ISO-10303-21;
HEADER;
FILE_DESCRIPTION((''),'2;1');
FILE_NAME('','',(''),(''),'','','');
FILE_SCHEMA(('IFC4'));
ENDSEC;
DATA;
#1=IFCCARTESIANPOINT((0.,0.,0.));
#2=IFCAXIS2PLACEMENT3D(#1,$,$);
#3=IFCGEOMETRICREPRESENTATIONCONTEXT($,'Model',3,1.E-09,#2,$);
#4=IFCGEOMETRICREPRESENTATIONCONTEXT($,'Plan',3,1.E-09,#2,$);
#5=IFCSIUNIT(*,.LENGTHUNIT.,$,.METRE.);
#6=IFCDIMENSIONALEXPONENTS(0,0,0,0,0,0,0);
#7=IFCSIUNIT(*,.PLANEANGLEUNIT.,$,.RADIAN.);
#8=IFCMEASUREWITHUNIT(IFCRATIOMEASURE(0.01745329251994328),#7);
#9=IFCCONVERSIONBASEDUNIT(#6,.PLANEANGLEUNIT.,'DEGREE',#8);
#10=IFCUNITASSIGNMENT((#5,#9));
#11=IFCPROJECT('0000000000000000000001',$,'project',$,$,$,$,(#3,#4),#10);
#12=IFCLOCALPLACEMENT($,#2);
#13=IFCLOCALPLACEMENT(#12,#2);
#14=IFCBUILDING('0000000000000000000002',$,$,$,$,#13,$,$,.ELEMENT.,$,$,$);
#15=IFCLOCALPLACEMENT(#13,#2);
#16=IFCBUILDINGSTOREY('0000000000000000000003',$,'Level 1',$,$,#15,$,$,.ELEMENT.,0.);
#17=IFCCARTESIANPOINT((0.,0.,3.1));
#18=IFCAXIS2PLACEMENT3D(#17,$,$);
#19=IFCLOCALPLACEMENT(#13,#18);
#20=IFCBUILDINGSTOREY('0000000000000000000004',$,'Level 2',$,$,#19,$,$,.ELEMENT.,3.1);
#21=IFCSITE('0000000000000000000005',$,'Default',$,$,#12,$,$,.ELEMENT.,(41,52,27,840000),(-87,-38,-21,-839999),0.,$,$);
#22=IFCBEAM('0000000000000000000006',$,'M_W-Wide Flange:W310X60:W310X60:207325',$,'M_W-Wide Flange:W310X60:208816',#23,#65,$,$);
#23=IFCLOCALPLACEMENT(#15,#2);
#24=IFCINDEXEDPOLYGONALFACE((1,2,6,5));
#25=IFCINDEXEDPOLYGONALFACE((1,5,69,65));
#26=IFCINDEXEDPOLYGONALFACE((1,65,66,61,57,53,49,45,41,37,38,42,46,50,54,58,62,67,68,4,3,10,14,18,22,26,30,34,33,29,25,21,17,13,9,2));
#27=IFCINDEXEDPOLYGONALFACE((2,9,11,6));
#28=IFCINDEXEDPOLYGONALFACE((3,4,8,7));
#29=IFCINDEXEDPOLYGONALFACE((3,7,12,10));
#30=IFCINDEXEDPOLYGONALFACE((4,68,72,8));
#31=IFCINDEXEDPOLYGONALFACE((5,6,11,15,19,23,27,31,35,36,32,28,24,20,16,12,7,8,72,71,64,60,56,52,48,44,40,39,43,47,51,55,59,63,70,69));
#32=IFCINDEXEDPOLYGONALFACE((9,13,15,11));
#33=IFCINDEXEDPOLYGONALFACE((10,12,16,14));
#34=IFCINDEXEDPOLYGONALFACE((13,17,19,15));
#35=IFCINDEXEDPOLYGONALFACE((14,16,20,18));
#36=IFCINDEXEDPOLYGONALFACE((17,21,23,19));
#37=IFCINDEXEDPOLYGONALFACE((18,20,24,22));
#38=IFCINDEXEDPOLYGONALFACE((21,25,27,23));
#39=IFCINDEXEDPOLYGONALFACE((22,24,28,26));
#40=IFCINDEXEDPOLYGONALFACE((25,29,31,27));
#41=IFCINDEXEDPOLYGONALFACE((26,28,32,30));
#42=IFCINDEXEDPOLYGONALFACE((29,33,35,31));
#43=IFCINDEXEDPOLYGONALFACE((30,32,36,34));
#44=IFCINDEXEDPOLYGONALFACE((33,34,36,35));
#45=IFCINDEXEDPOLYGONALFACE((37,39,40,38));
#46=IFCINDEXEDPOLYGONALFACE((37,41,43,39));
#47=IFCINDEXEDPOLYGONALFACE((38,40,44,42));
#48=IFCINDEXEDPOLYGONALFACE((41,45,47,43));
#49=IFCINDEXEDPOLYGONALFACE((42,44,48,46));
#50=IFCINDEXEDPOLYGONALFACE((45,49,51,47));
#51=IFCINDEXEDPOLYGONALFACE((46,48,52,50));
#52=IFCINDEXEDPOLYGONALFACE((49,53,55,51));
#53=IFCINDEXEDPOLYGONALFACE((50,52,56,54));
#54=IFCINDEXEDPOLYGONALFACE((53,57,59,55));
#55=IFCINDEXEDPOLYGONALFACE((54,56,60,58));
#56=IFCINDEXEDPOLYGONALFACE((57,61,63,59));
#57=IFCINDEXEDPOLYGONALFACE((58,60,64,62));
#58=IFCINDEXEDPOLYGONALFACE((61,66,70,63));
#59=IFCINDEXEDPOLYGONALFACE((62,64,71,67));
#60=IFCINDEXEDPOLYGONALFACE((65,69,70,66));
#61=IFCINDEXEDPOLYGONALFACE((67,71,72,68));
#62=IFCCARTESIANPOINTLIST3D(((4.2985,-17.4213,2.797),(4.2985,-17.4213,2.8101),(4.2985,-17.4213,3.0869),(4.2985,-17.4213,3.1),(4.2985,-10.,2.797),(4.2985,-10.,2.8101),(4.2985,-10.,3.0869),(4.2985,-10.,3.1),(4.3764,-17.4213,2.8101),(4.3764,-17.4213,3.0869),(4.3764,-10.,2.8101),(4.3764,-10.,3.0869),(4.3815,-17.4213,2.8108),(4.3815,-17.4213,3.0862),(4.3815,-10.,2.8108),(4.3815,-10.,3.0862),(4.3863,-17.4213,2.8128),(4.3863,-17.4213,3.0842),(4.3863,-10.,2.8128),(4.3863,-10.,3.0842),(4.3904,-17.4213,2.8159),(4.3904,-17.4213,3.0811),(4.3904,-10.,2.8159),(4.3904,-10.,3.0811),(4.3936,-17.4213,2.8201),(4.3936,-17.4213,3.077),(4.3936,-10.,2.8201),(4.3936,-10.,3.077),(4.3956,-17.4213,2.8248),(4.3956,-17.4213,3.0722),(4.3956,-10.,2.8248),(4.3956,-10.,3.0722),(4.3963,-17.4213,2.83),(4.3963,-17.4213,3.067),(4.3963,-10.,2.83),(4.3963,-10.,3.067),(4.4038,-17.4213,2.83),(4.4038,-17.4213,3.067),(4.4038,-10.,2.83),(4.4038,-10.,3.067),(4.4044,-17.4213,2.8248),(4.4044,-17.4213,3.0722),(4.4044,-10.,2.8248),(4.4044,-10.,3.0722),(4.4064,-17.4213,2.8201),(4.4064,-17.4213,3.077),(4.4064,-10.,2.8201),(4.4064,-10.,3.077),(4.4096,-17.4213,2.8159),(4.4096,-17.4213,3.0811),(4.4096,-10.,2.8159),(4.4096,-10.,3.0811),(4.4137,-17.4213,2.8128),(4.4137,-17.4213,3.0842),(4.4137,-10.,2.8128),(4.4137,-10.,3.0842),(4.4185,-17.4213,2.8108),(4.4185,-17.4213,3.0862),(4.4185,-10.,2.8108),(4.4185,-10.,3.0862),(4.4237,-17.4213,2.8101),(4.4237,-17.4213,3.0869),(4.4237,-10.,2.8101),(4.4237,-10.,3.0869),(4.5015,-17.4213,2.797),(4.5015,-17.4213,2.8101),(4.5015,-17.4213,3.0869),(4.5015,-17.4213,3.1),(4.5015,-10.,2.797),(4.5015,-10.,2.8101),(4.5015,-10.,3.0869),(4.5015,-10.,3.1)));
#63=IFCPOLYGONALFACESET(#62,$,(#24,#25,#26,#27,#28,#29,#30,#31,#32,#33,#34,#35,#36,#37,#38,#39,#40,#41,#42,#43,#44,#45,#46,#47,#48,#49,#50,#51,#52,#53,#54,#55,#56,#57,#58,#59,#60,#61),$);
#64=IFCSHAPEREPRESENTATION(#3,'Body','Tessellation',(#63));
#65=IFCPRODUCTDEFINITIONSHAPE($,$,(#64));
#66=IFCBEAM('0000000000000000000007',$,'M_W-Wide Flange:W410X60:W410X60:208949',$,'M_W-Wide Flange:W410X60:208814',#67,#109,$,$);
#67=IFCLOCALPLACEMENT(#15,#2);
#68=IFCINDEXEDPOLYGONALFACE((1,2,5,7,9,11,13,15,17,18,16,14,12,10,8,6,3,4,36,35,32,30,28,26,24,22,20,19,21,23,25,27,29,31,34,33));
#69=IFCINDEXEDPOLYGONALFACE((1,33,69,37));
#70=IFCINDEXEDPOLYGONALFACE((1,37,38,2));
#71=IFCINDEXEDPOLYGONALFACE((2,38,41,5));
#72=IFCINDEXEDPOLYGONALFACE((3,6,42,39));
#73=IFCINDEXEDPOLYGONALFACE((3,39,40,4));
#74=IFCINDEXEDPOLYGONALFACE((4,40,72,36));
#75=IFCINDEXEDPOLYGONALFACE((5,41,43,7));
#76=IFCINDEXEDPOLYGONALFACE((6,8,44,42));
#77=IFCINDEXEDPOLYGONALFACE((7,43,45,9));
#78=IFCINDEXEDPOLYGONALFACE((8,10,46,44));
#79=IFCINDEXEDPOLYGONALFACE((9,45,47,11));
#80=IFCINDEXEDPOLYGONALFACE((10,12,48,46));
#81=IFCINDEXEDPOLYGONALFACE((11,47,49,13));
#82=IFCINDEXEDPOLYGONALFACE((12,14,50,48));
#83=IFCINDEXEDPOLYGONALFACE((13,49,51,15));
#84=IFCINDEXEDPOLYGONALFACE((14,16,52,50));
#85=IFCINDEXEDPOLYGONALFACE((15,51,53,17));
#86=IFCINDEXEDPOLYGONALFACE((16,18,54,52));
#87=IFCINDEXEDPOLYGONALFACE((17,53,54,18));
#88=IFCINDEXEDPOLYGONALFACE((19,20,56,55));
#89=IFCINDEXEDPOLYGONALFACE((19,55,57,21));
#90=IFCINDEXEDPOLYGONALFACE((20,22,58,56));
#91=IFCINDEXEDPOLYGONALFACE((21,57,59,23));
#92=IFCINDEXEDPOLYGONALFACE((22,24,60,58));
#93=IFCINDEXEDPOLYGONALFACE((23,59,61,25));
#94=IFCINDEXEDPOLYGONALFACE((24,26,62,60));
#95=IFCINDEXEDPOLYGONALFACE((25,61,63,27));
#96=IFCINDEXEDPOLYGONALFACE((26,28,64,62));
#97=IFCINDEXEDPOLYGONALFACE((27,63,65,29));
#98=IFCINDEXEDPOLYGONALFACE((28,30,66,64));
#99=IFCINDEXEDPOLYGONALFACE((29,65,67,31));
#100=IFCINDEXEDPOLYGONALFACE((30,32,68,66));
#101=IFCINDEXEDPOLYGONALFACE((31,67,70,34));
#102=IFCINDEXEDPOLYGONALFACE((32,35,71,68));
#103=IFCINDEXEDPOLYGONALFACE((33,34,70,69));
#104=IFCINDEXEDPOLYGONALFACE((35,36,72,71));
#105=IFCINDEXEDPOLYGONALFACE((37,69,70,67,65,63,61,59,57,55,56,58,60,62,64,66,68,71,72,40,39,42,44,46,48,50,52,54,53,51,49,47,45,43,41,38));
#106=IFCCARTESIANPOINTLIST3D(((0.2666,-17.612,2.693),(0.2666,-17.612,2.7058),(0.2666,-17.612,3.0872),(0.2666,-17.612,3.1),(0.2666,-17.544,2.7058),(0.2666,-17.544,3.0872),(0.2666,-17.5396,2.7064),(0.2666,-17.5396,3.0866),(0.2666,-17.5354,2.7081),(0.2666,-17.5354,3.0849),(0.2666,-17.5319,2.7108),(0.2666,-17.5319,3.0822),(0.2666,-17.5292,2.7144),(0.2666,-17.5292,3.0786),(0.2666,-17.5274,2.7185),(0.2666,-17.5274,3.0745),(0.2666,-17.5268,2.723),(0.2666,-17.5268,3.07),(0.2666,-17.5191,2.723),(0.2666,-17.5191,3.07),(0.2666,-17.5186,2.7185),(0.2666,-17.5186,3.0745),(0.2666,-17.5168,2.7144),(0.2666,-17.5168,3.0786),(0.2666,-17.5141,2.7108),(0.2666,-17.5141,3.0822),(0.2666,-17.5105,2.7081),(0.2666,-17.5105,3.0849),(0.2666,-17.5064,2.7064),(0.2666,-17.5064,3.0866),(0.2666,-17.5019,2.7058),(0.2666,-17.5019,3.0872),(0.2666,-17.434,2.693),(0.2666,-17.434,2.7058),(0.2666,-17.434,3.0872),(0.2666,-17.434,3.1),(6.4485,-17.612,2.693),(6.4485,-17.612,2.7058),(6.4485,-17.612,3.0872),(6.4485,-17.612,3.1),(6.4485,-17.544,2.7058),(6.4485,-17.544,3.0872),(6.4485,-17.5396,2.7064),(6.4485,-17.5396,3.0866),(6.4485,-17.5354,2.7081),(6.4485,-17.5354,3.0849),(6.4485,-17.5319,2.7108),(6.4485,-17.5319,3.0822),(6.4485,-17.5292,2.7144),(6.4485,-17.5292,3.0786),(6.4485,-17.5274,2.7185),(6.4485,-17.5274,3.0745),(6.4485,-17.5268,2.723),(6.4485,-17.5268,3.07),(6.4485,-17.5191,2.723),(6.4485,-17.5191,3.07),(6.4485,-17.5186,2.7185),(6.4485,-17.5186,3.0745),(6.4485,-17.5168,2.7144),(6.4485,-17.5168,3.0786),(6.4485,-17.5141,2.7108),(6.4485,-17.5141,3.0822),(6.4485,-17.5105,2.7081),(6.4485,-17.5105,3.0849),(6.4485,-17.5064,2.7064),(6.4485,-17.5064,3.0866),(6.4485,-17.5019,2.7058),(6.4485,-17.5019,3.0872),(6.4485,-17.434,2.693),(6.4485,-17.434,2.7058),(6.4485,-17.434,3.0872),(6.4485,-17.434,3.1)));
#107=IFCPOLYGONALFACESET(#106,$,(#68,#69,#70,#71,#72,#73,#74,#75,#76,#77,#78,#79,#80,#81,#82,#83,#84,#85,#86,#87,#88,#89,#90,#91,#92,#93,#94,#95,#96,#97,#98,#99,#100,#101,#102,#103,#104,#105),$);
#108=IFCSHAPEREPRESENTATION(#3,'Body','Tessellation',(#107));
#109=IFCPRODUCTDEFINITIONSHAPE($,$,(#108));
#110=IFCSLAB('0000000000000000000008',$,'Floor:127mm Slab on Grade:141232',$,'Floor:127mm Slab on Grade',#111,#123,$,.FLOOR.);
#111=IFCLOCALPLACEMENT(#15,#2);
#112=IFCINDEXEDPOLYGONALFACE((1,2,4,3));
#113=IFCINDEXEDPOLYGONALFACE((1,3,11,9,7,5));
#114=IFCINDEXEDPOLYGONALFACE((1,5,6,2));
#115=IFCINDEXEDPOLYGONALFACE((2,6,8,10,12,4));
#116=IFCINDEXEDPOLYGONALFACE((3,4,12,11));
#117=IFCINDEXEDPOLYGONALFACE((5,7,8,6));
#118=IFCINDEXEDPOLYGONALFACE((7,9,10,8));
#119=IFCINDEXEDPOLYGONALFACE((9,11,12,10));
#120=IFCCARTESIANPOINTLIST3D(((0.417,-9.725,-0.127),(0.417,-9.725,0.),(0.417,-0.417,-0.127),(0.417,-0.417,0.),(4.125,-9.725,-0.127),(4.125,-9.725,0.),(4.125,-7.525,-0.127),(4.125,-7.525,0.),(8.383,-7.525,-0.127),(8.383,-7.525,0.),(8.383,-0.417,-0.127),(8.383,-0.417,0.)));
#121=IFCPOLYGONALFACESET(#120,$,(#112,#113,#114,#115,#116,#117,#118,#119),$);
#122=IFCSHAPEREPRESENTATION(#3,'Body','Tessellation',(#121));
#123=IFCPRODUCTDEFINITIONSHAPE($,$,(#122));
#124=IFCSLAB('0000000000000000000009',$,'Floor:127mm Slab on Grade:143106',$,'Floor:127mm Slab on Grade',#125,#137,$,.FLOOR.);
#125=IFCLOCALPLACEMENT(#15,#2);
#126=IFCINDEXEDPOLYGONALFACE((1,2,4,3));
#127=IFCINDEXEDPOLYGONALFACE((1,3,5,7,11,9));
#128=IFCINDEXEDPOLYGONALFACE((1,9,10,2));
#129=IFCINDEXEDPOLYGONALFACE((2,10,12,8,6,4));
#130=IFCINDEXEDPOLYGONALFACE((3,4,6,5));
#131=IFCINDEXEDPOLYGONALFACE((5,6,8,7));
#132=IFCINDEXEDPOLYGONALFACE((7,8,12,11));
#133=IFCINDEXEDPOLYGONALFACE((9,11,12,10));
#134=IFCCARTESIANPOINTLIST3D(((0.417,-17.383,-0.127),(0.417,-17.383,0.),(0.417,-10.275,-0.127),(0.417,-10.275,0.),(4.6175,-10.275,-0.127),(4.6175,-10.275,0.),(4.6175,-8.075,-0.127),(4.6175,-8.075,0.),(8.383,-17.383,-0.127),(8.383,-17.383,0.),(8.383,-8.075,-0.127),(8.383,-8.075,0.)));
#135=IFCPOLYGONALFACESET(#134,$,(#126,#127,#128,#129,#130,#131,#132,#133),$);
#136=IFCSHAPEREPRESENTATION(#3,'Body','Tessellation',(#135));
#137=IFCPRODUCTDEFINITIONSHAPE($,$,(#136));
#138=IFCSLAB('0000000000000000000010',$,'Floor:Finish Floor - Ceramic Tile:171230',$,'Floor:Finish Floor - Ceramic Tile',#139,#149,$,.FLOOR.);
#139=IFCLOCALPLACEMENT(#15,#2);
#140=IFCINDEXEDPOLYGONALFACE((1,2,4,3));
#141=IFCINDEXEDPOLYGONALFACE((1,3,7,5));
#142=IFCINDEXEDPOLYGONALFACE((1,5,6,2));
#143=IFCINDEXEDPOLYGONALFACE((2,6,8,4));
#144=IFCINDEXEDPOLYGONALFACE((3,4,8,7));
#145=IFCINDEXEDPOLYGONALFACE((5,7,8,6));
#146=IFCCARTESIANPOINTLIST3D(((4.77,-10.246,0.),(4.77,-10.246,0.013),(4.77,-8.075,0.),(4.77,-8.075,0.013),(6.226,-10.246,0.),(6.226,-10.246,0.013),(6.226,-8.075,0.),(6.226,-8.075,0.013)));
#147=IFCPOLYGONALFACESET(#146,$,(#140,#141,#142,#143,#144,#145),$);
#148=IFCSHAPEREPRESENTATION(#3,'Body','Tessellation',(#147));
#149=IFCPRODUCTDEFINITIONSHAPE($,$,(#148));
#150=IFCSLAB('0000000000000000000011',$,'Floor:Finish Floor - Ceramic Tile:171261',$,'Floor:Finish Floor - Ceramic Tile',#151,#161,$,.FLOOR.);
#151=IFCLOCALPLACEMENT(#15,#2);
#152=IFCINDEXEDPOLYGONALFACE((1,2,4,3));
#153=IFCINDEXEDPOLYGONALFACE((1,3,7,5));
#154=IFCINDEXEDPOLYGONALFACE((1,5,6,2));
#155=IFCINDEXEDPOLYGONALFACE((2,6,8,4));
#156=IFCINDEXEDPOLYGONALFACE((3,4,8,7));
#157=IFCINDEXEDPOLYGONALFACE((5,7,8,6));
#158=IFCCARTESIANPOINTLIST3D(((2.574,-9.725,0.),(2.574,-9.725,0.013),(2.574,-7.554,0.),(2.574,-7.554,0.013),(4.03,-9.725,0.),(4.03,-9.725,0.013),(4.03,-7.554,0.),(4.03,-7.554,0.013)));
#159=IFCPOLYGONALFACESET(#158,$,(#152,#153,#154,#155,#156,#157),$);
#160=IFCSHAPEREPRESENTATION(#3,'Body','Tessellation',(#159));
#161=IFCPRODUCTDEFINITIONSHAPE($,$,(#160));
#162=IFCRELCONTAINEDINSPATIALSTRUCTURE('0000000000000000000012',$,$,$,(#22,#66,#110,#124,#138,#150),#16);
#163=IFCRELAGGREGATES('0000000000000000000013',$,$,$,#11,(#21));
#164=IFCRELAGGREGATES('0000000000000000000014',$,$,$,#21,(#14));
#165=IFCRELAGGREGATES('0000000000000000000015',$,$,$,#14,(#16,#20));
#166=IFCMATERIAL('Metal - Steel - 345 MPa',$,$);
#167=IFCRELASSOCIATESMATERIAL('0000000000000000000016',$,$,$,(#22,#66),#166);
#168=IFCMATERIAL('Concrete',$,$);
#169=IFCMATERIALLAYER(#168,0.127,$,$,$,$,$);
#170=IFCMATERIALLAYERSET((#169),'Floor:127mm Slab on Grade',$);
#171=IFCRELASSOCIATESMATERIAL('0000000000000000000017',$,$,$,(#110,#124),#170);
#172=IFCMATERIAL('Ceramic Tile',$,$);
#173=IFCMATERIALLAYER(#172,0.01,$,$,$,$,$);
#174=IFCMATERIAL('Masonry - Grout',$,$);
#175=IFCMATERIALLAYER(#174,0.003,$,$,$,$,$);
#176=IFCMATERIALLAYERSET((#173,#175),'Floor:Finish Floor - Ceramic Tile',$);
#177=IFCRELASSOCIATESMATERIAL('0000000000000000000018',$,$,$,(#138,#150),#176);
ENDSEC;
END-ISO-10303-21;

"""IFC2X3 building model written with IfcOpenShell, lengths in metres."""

from ifc_helpers import new_model, entity, si_unit, converted_unit, frame, frame_2d, origin, place, context, project, spatial, polyline, circle_curve, parameter, trimmed, segment, composite_curve, rectangle, outline, extrude, material, layer, layer_set, layer_usage, element, save


model = new_model("IFC2X3")

# Units and contexts
model_context = context("Model", 3, precision=1e-09, world=origin())
plan_context = context("Plan", 3, precision=1e-09, world=origin())
ifc_project = project(units=[si_unit("LENGTHUNIT", "METRE"), converted_unit("PLANEANGLEUNIT", "DEGREE", entity("IfcRatioMeasure", 0.01745329251994328), si_unit("PLANEANGLEUNIT", "RADIAN"), dimensions=[0, 0, 0, 0, 0, 0, 0])], contexts=[model_context, plan_context])

# Site, building, storey
site_placement = place(None, origin())
site = spatial("IfcSite", under=ifc_project, at=site_placement, Name="Default", CompositionType="ELEMENT", RefLatitude=(41, 52, 27, 840000), RefLongitude=(-87, -38, -21, -839999), RefElevation=0.0)
building_placement = place(site_placement, origin())
building = spatial("IfcBuilding", under=site, at=building_placement, CompositionType="ELEMENT")
storey_1_placement = place(building_placement, origin())
storey_1 = spatial("IfcBuildingStorey", under=building, at=storey_1_placement, Name="Level 1", CompositionType="ELEMENT", Elevation=0.0)

# Beams
ifc_material_1 = material(Name="Metal - Steel - 345 MPa")
beam_1_placement = place(storey_1_placement, frame((4.4, -10.0, 3.1), z_axis=(0.0, 0.0, 1.0), x_axis=(-1.0, 0.0, 0.0)))
element("IfcBeam", 1, at=beam_1_placement, inside=storey_1, material=ifc_material_1, Name="M_W-Wide Flange:W310X60:W310X60:207325", ObjectType="M_W-Wide Flange:W310X60:208816", context=model_context, shape_type="SweptSolid", body=[
    extrude(outline(composite_curve([segment(polyline([(0.1384, -0.1015), (0.1515, -0.1015)]), True, "CONTINUOUS"), segment(polyline([(0.1515, -0.1015), (0.1515, 0.1015)]), True, "CONTINUOUS"), segment(polyline([(0.1515, 0.1015), (0.1384, 0.1015)]), True, "CONTINUOUS"), segment(polyline([(0.1384, 0.1015), (0.1384, 0.0236)]), True, "CONTINUOUS"), segment(trimmed(circle_curve(frame_2d((0.1185, 0.0236), x_axis=(0.0, 1.0)), 0.0199), [parameter(180.0)], [parameter(270.0)], True, "PARAMETER"), False, "CONTINUOUS"), segment(polyline([(0.1185, 0.0037), (-0.1185, 0.0037)]), True, "CONTINUOUS"), segment(trimmed(circle_curve(frame_2d((-0.1185, 0.0236), x_axis=(0.0, 1.0)), 0.0199), [parameter(90.0)], [parameter(180.0)], True, "PARAMETER"), False, "CONTINUOUS"), segment(polyline([(-0.1384, 0.0236), (-0.1384, 0.1015)]), True, "CONTINUOUS"), segment(polyline([(-0.1384, 0.1015), (-0.1515, 0.1015)]), True, "CONTINUOUS"), segment(polyline([(-0.1515, 0.1015), (-0.1515, -0.1015)]), True, "CONTINUOUS"), segment(polyline([(-0.1515, -0.1015), (-0.1384, -0.1015)]), True, "CONTINUOUS"), segment(polyline([(-0.1384, -0.1015), (-0.1384, -0.0237)]), True, "CONTINUOUS"), segment(trimmed(circle_curve(frame_2d((-0.1185, -0.0237), x_axis=(0.0, 1.0)), 0.0199), [parameter(360.0)], [parameter(90.0)], True, "PARAMETER"), False, "CONTINUOUS"), segment(polyline([(-0.1185, -0.0038), (0.1185, -0.0038)]), True, "CONTINUOUS"), segment(trimmed(circle_curve(frame_2d((0.1185, -0.0237), x_axis=(0.0, 1.0)), 0.0199), [parameter(270.0)], [parameter(0.0)], True, "PARAMETER"), False, "CONTINUOUS"), segment(polyline([(0.1384, -0.0237), (0.1384, -0.1015)]), True, "CONTINUOUS")], self_intersect=False)), frame((0.0, 7.4213, -0.1515), z_axis=(0.0, -1.0, 0.0), x_axis=(0.0, 0.0, -1.0)), (0.0, 0.0, 1.0), 7.4213),
])
beam_2_placement = place(storey_1_placement, frame((0.2085, -17.523, 3.1), z_axis=(0.0, 0.0, 1.0), x_axis=(0.0, -1.0, 0.0)))
element("IfcBeam", 2, at=beam_2_placement, inside=storey_1, material=ifc_material_1, Name="M_W-Wide Flange:W410X60:W410X60:208949", ObjectType="M_W-Wide Flange:W410X60:208814", context=model_context, shape_type="SweptSolid", body=[
    extrude(outline(composite_curve([segment(polyline([(-0.089, -0.1907), (-0.089, -0.2035)]), True, "CONTINUOUS"), segment(polyline([(-0.089, -0.2035), (0.089, -0.2035)]), True, "CONTINUOUS"), segment(polyline([(0.089, -0.2035), (0.089, -0.1907)]), True, "CONTINUOUS"), segment(polyline([(0.089, -0.1907), (0.021, -0.1907)]), True, "CONTINUOUS"), segment(trimmed(circle_curve(frame_2d((0.021, -0.1735), x_axis=(0.0, -1.0)), 0.0172), [parameter(270.0)], [parameter(360.0)], True, "PARAMETER"), False, "CONTINUOUS"), segment(polyline([(0.0038, -0.1735), (0.0038, 0.1735)]), True, "CONTINUOUS"), segment(trimmed(circle_curve(frame_2d((0.021, 0.1735), x_axis=(-1.0, 0.0)), 0.0172), [parameter(270.0)], [parameter(360.0)], True, "PARAMETER"), False, "CONTINUOUS"), segment(polyline([(0.021, 0.1907), (0.089, 0.1907)]), True, "CONTINUOUS"), segment(polyline([(0.089, 0.1907), (0.089, 0.2035)]), True, "CONTINUOUS"), segment(polyline([(0.089, 0.2035), (-0.089, 0.2035)]), True, "CONTINUOUS"), segment(polyline([(-0.089, 0.2035), (-0.089, 0.1907)]), True, "CONTINUOUS"), segment(polyline([(-0.089, 0.1907), (-0.0211, 0.1907)]), True, "CONTINUOUS"), segment(trimmed(circle_curve(frame_2d((-0.0211, 0.1735), x_axis=(0.0, 1.0)), 0.0172), [parameter(270.0)], [parameter(0.0)], True, "PARAMETER"), False, "CONTINUOUS"), segment(polyline([(-0.0039, 0.1735), (-0.0039, -0.1735)]), True, "CONTINUOUS"), segment(trimmed(circle_curve(frame_2d((-0.0211, -0.1735), x_axis=(1.0, 0.0)), 0.0172), [parameter(270.0)], [parameter(0.0)], True, "PARAMETER"), False, "CONTINUOUS"), segment(polyline([(-0.0211, -0.1907), (-0.089, -0.1907)]), True, "CONTINUOUS")], self_intersect=False)), frame((0.0, 0.0581, -0.2035), z_axis=(0.0, -1.0, 0.0), x_axis=(1.0, 0.0, 0.0)), (0.0, 0.0, -1.0), 6.1819),
])

# Slabs
ifc_material_2 = material(Name="Concrete")
ifc_layer_1 = layer(ifc_material_2, 0.127)
ifc_layer_set_1 = layer_set([ifc_layer_1], Name="Floor:127mm Slab on Grade")
ifc_layer_usage_1 = layer_usage(ifc_layer_set_1, "AXIS3", "POSITIVE", 0.0)
slab_1_placement = place(storey_1_placement, frame((0.417, -9.725, -0.127)))
element("IfcSlab", 3, at=slab_1_placement, inside=storey_1, material=ifc_layer_usage_1, Name="Floor:127mm Slab on Grade:141232", ObjectType="Floor:127mm Slab on Grade", PredefinedType="FLOOR", context=model_context, shape_type="SweptSolid", body=[
    extrude(outline(polyline([(-3.983, 4.654), (-3.983, -2.454), (0.275, -2.454), (0.275, -4.654), (3.983, -4.654), (3.983, 4.654), (-3.983, 4.654)])), frame((3.983, 4.654, 0.127), z_axis=(0.0, 0.0, -1.0), x_axis=(-1.0, 0.0, 0.0)), (0.0, 0.0, 1.0), 0.127),
])
slab_2_placement = place(storey_1_placement, frame((0.417, -17.383, -0.127)))
element("IfcSlab", 4, at=slab_2_placement, inside=storey_1, material=ifc_layer_usage_1, Name="Floor:127mm Slab on Grade:143106", ObjectType="Floor:127mm Slab on Grade", PredefinedType="FLOOR", context=model_context, shape_type="SweptSolid", body=[
    extrude(outline(polyline([(-3.983, 4.654), (-3.983, -4.654), (3.983, -4.654), (3.983, 2.454), (-0.2175, 2.454), (-0.2175, 4.654), (-3.983, 4.654)])), frame((3.983, 4.654, 0.127), z_axis=(0.0, 0.0, -1.0), x_axis=(-1.0, 0.0, 0.0)), (0.0, 0.0, 1.0), 0.127),
])
ifc_material_3 = material(Name="Ceramic Tile")
ifc_layer_2 = layer(ifc_material_3, 0.01)
ifc_material_4 = material(Name="Masonry - Grout")
ifc_layer_3 = layer(ifc_material_4, 0.003)
ifc_layer_set_2 = layer_set([ifc_layer_2, ifc_layer_3], Name="Floor:Finish Floor - Ceramic Tile")
ifc_layer_usage_2 = layer_usage(ifc_layer_set_2, "AXIS3", "POSITIVE", 0.0)
slab_3_placement = place(storey_1_placement, frame((4.77, -10.246, 0.0)))
element("IfcSlab", 5, at=slab_3_placement, inside=storey_1, material=ifc_layer_usage_2, Name="Floor:Finish Floor - Ceramic Tile:171230", ObjectType="Floor:Finish Floor - Ceramic Tile", PredefinedType="FLOOR", context=model_context, shape_type="SweptSolid", body=[
    extrude(rectangle(XDim=1.456, YDim=2.171, at=frame_2d((0.0, 0.0), x_axis=(-1.0, 0.0))), frame((0.728, 1.0855, 0.013), z_axis=(0.0, 0.0, -1.0), x_axis=(-1.0, 0.0, 0.0)), (0.0, 0.0, 1.0), 0.013),
])
slab_4_placement = place(storey_1_placement, frame((2.574, -9.725, 0.0)))
element("IfcSlab", 6, at=slab_4_placement, inside=storey_1, material=ifc_layer_usage_2, Name="Floor:Finish Floor - Ceramic Tile:171261", ObjectType="Floor:Finish Floor - Ceramic Tile", PredefinedType="FLOOR", context=model_context, shape_type="SweptSolid", body=[
    extrude(rectangle(XDim=2.171, YDim=1.456, at=frame_2d((0.0, 0.0), x_axis=(0.0, -1.0))), frame((0.728, 1.0855, 0.013), z_axis=(0.0, 0.0, -1.0), x_axis=(-1.0, 0.0, 0.0)), (0.0, 0.0, 1.0), 0.013),
])

# Shared definitions
storey_2_placement = place(building_placement, frame((0.0, 0.0, 3.1)))
storey_2 = spatial("IfcBuildingStorey", under=building, at=storey_2_placement, Name="Level 2", CompositionType="ELEMENT", Elevation=3.1)

save(model, "model.ifc")
